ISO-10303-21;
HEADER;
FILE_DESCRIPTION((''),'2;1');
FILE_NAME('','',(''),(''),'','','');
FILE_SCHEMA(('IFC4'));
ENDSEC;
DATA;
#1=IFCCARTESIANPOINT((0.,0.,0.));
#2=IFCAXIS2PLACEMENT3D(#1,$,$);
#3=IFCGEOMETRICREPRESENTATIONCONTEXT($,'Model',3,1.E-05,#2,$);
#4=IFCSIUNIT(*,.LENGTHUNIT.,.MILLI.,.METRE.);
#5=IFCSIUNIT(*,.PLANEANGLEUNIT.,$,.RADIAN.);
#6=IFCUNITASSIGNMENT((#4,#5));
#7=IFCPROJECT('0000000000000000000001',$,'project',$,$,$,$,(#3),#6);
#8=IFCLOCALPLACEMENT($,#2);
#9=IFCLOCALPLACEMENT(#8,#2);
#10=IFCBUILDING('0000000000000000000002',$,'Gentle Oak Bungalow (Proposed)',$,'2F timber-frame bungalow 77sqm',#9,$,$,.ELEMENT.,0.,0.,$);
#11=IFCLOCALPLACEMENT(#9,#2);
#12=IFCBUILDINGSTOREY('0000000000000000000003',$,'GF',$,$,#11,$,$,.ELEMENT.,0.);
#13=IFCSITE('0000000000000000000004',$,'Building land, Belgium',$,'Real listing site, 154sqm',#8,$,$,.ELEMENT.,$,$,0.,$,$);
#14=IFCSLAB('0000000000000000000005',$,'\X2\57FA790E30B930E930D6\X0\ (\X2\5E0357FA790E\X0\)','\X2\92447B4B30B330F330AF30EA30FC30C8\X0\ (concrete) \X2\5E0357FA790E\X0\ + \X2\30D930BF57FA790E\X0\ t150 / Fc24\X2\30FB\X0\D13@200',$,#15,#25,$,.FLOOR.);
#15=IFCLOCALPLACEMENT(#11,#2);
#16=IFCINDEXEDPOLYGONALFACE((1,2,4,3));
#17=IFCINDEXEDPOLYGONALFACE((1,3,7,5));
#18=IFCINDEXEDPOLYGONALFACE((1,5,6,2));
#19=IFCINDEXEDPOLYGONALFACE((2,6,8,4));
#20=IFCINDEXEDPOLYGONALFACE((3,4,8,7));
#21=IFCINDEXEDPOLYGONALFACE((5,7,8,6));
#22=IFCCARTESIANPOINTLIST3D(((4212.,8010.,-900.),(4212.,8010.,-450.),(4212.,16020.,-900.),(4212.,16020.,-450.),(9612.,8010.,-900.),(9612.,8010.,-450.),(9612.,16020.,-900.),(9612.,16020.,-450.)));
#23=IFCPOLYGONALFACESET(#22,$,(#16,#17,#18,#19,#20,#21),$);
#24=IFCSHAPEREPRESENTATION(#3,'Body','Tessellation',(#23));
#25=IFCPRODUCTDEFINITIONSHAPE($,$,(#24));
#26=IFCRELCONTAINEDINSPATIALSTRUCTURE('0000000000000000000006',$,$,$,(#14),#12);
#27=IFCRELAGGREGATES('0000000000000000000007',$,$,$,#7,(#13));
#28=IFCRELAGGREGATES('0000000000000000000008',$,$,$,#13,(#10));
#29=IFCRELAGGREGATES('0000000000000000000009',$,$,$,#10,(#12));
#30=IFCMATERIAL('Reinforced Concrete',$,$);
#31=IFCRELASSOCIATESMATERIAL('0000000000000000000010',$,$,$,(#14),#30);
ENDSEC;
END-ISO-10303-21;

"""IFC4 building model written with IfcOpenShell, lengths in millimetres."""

from ifc_helpers import new_model, si_unit, frame, frame_2d, origin, place, context, project, spatial, rectangle, extrude, material, element, save


model = new_model("IFC4")

# Units and contexts
model_context = context("Model", 3, precision=1e-05, world=origin())
ifc_project = project(units=[si_unit("LENGTHUNIT", "METRE", prefix="MILLI"), si_unit("PLANEANGLEUNIT", "RADIAN")], contexts=[model_context])

# Site, building, storey
site_placement = place(None, origin())
site = spatial("IfcSite", under=ifc_project, at=site_placement, Name="Building land, Belgium", ObjectType="Real listing site, 154sqm", CompositionType="ELEMENT", RefElevation=0.0)
building_placement = place(site_placement, origin())
building = spatial("IfcBuilding", under=site, at=building_placement, Name="Gentle Oak Bungalow (Proposed)", ObjectType="2F timber-frame bungalow 77sqm", CompositionType="ELEMENT", ElevationOfRefHeight=0.0, ElevationOfTerrain=0.0)
storey_placement = place(building_placement, origin())
storey = spatial("IfcBuildingStorey", under=building, at=storey_placement, Name="GF", CompositionType="ELEMENT", Elevation=0.0)

# Slab
ifc_material_1 = material(Name="Reinforced Concrete")
slab_1_placement = place(storey_placement, frame((2106.0, 4005.0, -450.0)))
element("IfcSlab", 1, at=slab_1_placement, inside=storey, material=ifc_material_1, Name="基礎スラブ (布基礎)", Description="鉄筋コンクリート (concrete) 布基礎 + ベタ基礎 t150 / Fc24・D13@200", PredefinedType="FLOOR", context=model_context, shape_type="SweptSolid", body=[
    extrude(rectangle(XDim=5400.0, YDim=8010.0, at=frame_2d((2700.0, 4005.0))), frame((2106.0, 4005.0, -450.0)), (0.0, 0.0, 1.0), 450.0),
])

save(model, "model.ifc")
